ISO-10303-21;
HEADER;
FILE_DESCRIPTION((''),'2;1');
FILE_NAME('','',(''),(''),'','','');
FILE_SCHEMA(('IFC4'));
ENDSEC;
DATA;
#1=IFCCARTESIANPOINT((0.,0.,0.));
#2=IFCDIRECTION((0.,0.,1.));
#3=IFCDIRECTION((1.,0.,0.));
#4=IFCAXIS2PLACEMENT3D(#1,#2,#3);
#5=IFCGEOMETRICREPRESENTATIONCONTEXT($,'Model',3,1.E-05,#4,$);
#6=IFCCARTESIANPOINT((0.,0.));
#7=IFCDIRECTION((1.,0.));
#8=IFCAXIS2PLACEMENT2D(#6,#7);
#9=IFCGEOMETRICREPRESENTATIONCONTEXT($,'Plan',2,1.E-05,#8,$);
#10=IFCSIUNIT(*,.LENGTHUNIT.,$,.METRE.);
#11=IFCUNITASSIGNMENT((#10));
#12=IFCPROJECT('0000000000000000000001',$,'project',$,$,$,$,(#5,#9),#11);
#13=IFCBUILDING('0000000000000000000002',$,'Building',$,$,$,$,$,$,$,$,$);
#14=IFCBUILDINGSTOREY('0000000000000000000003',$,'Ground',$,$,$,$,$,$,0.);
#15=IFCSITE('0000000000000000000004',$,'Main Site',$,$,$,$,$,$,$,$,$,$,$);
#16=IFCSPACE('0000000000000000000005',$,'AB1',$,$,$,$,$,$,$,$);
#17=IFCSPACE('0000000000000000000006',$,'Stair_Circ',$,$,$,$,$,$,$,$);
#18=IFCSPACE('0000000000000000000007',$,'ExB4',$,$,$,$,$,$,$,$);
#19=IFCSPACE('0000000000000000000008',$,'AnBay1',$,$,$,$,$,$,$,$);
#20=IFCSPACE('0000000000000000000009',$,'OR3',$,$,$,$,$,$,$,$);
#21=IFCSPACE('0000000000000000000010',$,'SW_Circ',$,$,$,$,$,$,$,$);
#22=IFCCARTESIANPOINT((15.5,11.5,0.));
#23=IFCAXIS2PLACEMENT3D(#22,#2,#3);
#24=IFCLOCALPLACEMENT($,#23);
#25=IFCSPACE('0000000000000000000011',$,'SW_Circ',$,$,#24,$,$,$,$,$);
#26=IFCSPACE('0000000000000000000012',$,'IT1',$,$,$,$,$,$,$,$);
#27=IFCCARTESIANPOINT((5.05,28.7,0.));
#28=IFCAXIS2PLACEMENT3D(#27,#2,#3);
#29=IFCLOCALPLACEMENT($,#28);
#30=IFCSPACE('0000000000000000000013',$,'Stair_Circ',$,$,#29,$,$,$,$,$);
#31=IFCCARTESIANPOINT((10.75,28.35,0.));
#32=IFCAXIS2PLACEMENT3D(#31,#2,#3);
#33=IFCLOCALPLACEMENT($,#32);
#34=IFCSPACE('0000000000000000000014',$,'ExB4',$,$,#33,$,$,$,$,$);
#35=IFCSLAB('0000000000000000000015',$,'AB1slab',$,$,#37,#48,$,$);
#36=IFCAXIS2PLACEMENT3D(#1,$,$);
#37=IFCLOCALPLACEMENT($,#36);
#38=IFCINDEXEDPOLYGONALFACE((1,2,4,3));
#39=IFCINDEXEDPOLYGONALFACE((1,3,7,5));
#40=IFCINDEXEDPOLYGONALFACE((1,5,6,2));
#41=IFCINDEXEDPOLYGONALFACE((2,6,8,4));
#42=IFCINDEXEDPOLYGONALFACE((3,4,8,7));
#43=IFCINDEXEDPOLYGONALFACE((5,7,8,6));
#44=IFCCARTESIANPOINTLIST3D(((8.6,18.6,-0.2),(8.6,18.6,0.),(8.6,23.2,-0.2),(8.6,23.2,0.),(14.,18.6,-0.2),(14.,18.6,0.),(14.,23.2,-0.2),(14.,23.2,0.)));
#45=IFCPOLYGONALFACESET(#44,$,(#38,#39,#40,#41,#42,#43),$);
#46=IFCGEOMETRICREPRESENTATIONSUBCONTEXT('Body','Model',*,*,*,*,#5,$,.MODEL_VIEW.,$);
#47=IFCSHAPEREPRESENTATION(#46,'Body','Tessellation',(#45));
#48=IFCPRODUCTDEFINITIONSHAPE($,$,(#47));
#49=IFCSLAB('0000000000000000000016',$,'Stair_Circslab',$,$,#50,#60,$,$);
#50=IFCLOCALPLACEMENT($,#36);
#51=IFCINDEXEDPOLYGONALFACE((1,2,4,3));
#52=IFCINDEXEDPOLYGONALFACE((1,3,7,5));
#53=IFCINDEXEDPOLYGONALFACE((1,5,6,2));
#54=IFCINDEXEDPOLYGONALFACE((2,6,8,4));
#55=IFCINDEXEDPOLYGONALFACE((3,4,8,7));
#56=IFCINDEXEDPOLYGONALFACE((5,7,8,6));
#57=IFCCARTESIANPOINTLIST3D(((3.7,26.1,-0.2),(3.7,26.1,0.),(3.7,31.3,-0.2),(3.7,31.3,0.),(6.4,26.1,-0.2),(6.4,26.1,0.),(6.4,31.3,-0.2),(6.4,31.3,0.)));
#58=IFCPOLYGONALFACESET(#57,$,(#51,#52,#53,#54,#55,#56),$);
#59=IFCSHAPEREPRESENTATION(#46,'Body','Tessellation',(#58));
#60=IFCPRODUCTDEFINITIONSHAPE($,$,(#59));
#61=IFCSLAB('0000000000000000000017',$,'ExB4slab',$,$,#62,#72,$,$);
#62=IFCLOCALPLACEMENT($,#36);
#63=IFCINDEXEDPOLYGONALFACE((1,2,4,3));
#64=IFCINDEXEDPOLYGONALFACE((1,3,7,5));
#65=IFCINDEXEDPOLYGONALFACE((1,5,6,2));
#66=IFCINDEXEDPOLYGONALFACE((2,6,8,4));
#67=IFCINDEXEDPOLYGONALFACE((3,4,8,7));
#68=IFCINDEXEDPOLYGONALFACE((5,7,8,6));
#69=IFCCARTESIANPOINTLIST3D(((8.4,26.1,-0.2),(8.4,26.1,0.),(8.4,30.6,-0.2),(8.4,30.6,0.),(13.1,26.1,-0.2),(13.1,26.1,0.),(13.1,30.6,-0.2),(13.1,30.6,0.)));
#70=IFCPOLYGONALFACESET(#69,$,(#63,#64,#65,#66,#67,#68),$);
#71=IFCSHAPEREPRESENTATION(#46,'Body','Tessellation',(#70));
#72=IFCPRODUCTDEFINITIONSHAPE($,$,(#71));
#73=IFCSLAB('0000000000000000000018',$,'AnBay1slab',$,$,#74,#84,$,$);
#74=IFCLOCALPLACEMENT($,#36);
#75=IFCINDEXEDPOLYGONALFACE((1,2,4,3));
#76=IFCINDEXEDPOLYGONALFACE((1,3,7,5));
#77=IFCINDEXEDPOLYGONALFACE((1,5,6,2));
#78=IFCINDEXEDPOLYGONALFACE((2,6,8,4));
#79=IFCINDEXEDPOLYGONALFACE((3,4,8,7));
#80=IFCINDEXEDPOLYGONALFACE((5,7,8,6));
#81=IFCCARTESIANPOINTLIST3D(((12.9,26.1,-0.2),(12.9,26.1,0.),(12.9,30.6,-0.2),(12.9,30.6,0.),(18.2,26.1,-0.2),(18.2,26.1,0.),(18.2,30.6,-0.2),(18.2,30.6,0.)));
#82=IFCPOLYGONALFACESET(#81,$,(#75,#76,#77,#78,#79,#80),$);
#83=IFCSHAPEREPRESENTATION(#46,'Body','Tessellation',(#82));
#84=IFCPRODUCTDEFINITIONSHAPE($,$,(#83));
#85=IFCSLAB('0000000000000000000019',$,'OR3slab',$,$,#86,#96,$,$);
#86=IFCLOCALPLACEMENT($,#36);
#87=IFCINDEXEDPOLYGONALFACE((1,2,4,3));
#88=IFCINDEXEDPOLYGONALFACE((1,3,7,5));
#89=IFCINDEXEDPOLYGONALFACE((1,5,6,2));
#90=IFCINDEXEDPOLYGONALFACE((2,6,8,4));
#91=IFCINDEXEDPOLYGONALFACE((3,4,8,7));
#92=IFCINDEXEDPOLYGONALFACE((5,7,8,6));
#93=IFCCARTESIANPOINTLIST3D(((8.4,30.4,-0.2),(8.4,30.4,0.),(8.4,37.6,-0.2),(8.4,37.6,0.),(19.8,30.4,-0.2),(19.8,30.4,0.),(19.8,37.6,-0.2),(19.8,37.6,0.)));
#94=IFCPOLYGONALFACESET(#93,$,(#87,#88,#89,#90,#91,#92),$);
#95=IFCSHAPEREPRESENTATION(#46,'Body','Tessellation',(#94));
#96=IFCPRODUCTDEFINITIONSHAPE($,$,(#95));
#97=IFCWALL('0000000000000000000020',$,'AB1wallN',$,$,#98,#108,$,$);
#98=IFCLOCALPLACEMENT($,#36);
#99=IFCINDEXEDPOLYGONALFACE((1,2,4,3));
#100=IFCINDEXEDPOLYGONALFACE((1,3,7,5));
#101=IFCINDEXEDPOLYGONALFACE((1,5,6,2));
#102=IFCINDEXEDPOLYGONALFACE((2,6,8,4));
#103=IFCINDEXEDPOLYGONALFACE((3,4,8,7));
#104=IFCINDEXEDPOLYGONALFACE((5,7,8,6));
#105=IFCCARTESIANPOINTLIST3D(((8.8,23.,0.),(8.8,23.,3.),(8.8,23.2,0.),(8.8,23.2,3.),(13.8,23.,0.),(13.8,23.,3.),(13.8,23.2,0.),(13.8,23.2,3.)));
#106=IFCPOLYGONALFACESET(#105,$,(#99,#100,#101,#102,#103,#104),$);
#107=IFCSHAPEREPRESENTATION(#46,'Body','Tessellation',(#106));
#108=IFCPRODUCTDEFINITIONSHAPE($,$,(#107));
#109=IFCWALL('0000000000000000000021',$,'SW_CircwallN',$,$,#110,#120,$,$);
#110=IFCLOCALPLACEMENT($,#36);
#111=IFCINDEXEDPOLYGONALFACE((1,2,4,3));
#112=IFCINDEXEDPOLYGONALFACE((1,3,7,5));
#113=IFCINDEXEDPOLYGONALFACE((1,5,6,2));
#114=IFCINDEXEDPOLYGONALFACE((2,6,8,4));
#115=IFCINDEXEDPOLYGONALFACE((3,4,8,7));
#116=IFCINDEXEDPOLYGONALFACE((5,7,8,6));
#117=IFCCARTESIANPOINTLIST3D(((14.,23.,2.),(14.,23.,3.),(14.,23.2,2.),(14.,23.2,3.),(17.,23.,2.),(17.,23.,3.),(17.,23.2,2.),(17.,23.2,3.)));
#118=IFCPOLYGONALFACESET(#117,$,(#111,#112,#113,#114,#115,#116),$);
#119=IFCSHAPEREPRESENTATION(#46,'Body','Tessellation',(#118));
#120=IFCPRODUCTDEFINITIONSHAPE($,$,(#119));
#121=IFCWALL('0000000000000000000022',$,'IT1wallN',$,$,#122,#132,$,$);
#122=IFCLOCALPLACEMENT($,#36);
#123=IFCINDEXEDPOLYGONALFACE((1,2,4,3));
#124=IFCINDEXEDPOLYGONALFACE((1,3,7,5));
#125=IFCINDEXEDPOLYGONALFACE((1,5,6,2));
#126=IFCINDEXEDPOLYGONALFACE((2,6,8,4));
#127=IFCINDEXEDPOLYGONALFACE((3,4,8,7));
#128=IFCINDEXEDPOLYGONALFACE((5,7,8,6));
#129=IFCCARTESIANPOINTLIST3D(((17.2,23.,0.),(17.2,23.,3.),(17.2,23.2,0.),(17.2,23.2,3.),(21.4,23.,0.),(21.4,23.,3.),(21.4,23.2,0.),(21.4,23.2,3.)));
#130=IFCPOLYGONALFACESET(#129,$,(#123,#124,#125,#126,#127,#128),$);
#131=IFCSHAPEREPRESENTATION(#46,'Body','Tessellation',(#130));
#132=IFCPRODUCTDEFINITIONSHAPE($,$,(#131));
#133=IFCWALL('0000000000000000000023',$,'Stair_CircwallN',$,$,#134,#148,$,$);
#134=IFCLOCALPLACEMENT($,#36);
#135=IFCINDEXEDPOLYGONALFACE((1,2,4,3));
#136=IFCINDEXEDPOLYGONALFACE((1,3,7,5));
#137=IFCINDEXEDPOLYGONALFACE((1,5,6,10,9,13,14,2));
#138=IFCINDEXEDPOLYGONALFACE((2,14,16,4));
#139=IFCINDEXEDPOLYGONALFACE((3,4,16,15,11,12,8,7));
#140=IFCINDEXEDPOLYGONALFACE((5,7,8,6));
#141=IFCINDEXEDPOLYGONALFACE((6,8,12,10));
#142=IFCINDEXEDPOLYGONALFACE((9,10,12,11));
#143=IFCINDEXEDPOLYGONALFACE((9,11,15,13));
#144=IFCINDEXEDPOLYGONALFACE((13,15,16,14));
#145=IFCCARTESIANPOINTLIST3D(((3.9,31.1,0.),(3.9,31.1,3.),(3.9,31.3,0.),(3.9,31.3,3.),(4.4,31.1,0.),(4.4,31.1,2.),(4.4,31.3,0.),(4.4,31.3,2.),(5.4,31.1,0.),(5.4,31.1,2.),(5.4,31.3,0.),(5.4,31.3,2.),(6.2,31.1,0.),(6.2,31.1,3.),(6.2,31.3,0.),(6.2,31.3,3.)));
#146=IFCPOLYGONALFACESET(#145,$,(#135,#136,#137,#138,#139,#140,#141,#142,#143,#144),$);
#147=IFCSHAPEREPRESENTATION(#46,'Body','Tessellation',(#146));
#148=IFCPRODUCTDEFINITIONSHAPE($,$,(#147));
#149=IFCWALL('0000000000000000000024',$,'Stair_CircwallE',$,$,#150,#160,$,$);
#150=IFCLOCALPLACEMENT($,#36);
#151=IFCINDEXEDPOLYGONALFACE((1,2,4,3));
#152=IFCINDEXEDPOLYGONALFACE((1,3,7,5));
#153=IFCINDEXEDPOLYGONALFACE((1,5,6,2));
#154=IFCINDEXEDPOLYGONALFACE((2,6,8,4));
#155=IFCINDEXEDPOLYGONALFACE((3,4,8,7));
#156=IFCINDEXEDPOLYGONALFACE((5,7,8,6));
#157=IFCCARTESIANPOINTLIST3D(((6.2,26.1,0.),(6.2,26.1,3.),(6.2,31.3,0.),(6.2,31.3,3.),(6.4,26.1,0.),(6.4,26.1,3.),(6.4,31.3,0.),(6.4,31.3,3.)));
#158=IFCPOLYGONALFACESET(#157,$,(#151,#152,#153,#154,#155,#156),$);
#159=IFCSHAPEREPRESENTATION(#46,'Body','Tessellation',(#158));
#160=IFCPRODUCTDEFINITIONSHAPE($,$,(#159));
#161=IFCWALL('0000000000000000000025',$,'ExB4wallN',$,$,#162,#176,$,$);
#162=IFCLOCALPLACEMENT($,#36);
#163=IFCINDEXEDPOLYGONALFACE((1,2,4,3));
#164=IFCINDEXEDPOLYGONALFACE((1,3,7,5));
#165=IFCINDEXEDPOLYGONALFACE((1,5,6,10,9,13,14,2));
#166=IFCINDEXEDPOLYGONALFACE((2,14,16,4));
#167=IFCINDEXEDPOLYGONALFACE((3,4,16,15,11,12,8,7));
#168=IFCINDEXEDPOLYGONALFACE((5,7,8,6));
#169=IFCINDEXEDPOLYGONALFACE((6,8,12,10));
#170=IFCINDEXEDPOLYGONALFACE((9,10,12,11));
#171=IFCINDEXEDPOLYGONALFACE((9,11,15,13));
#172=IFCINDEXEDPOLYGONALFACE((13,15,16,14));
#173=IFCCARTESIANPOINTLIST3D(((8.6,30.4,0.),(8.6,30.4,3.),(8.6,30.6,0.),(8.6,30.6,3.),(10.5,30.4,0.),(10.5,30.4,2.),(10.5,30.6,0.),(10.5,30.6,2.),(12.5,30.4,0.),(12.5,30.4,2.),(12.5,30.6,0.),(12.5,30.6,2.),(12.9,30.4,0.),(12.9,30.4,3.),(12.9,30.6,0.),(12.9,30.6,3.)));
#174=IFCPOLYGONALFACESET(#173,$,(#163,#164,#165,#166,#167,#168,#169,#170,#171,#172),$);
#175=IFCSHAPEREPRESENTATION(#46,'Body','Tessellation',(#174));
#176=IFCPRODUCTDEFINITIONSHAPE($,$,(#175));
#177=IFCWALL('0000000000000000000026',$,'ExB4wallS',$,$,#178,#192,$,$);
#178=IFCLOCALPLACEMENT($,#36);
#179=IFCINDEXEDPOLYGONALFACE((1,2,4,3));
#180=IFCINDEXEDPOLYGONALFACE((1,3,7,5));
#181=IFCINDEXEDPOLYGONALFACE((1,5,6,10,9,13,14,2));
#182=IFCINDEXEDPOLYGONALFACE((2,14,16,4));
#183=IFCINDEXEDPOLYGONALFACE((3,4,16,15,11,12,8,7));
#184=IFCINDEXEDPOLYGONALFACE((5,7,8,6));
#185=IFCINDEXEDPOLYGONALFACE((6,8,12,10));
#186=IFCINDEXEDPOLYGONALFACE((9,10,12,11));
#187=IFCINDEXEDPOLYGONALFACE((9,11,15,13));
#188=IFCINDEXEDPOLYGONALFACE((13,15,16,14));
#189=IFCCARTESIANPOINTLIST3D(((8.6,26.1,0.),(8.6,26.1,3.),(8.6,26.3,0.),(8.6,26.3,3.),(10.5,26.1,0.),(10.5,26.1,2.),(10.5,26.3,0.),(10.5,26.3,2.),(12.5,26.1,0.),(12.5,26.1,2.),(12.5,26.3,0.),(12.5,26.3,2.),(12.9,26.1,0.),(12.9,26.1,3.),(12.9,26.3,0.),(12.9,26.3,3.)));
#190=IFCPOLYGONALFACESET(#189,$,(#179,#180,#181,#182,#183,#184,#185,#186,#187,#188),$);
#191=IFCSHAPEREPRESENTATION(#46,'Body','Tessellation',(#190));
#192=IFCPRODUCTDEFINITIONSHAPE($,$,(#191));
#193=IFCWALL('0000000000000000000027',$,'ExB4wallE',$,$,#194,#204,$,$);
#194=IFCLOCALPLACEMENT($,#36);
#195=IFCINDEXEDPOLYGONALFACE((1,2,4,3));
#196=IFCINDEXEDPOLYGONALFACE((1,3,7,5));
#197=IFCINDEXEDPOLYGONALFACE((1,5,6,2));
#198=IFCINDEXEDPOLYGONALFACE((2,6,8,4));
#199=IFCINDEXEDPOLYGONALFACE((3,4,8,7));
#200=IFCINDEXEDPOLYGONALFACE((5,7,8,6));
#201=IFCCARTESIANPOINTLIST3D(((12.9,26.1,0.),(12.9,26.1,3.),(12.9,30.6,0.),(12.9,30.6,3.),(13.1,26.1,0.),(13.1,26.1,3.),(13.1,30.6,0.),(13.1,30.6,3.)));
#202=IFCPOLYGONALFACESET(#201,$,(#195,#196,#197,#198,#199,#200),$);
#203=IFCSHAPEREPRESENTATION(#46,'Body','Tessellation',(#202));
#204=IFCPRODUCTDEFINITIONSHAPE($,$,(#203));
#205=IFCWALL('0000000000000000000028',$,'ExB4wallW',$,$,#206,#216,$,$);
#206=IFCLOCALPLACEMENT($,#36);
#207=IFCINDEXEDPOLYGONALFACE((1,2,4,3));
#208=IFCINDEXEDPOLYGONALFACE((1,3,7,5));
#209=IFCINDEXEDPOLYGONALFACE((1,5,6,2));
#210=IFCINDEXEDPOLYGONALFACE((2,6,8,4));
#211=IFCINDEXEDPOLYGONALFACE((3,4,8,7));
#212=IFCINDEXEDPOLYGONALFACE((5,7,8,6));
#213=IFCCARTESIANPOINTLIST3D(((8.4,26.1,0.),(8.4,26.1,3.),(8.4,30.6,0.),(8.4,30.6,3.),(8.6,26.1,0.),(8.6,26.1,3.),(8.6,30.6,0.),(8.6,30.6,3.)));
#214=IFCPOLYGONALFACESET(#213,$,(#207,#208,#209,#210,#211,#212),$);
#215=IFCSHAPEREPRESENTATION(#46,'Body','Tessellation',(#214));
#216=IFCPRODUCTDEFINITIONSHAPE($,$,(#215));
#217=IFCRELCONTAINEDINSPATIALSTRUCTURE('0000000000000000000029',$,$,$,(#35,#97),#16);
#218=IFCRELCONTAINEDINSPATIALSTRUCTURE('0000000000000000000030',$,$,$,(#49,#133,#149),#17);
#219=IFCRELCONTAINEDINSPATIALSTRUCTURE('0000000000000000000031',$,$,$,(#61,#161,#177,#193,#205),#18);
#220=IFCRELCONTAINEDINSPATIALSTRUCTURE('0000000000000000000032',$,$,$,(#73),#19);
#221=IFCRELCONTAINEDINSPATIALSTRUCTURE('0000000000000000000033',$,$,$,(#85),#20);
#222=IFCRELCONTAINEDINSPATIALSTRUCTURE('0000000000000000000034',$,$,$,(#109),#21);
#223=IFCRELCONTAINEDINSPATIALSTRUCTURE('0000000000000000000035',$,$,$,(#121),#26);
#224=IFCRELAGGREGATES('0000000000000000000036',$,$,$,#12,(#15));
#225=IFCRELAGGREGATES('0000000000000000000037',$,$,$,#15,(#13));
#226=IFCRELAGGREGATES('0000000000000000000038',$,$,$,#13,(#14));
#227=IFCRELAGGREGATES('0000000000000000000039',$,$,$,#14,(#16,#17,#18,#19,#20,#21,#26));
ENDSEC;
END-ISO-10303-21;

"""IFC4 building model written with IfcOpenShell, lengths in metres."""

from ifc_helpers import new_model, si_unit, frame, origin_with_axes, origin_2d_with_axis, place, context, subcontext, project, spatial, indexed_curve, rectangle, outline, extrude, element, save


model = new_model("IFC4")

# Units and contexts
model_context = context("Model", 3, precision=1e-05, world=origin_with_axes())
plan_context = context("Plan", 2, precision=1e-05, world=origin_2d_with_axis())
body_context = subcontext(model_context, "Body", "Model", "MODEL_VIEW")
ifc_project = project(units=[si_unit("LENGTHUNIT", "METRE")], contexts=[model_context, plan_context])

# Site, building, storey, space
site = spatial("IfcSite", under=ifc_project, Name="Main Site")
building = spatial("IfcBuilding", under=site, Name="Building")
storey = spatial("IfcBuildingStorey", under=building, Name="Ground", Elevation=0.0)
space_1 = spatial("IfcSpace", under=storey, Name="AB1")

# Slab
slab_1_placement = place(None, frame((11.3, 20.9, -0.2), z_axis=(0.0, 0.0, 1.0), x_axis=(1.0, 0.0, 0.0)))
element("IfcSlab", 1, at=slab_1_placement, inside=space_1, Name="AB1slab", context=body_context, shape_type="SweptSolid", body=[
    extrude(rectangle(XDim=5.4, YDim=4.6), origin_with_axes(), (0.0, 0.0, 1.0), 0.2),
])

# Shared definitions
space_2 = spatial("IfcSpace", under=storey, Name="Stair_Circ")

# Slab
slab_2_placement = place(None, frame((5.05, 28.7, -0.2), z_axis=(0.0, 0.0, 1.0), x_axis=(1.0, 0.0, 0.0)))
element("IfcSlab", 2, at=slab_2_placement, inside=space_2, Name="Stair_Circslab", context=body_context, shape_type="SweptSolid", body=[
    extrude(rectangle(XDim=2.7, YDim=5.2), origin_with_axes(), (0.0, 0.0, 1.0), 0.2),
])

# Shared definitions
space_3 = spatial("IfcSpace", under=storey, Name="ExB4")

# Slab
slab_3_placement = place(None, frame((10.75, 28.35, -0.2), z_axis=(0.0, 0.0, 1.0), x_axis=(1.0, 0.0, 0.0)))
element("IfcSlab", 3, at=slab_3_placement, inside=space_3, Name="ExB4slab", context=body_context, shape_type="SweptSolid", body=[
    extrude(rectangle(XDim=4.7, YDim=4.5), origin_with_axes(), (0.0, 0.0, 1.0), 0.2),
])

# Shared definitions
space_4 = spatial("IfcSpace", under=storey, Name="AnBay1")

# Slab
slab_4_placement = place(None, frame((15.55, 28.35, -0.2), z_axis=(0.0, 0.0, 1.0), x_axis=(1.0, 0.0, 0.0)))
element("IfcSlab", 4, at=slab_4_placement, inside=space_4, Name="AnBay1slab", context=body_context, shape_type="SweptSolid", body=[
    extrude(rectangle(XDim=5.3, YDim=4.5), origin_with_axes(), (0.0, 0.0, 1.0), 0.2),
])

# Shared definitions
space_5 = spatial("IfcSpace", under=storey, Name="OR3")

# Slab
slab_5_placement = place(None, frame((14.1, 34.0, -0.2), z_axis=(0.0, 0.0, 1.0), x_axis=(1.0, 0.0, 0.0)))
element("IfcSlab", 5, at=slab_5_placement, inside=space_5, Name="OR3slab", context=body_context, shape_type="SweptSolid", body=[
    extrude(rectangle(XDim=11.4, YDim=7.2), origin_with_axes(), (0.0, 0.0, 1.0), 0.2),
])

# Wall
wall_1_placement = place(None, frame((8.8, 23.0, 0.0), z_axis=(0.0, 0.0, 1.0), x_axis=(1.0, 0.0, 0.0)))
element("IfcWall", 6, at=wall_1_placement, inside=space_1, Name="AB1wallN", context=body_context, shape_type="SweptSolid", body=[
    extrude(outline(indexed_curve([(0.0, 0.0), (0.0, 0.2), (5.0, 0.2), (5.0, 0.0), (0.0, 0.0)], self_intersect=False)), origin_with_axes(), (0.0, 0.0, 1.0), 3.0),
])

# Shared definitions
space_6 = spatial("IfcSpace", under=storey, Name="SW_Circ")

# Wall
wall_2_placement = place(None, frame((14.0, 23.0, 0.0), z_axis=(0.0, 0.0, 1.0), x_axis=(1.0, 0.0, 0.0)))
wall_2 = element("IfcWall", 7, at=wall_2_placement, inside=space_6, Name="SW_CircwallN", context=body_context, shape_type="SweptSolid", body=[
    extrude(outline(indexed_curve([(0.0, 0.0), (0.0, 0.2), (3.0, 0.2), (3.0, 0.0), (0.0, 0.0)], self_intersect=False)), origin_with_axes(), (0.0, 0.0, 1.0), 3.0),
])

# Shared definitions
space_7_placement = place(None, frame((15.5, 11.5, 0.0), z_axis=(0.0, 0.0, 1.0), x_axis=(1.0, 0.0, 0.0)))
space_7 = spatial("IfcSpace", at=space_7_placement, Name="SW_Circ")

# Opening
opening_1_placement = place(wall_2_placement, origin_with_axes())
element("IfcOpeningElement", 8, at=opening_1_placement, inside=space_7, cuts=wall_2, context=body_context, shape_type="SweptSolid", body=[
    extrude(outline(indexed_curve([(0.0, 0.0), (0.0, 0.4), (3.0, 0.4), (3.0, 0.0), (0.0, 0.0)], self_intersect=False)), origin_with_axes(), (0.0, 0.0, 1.0), 2.0),
])

# Shared definitions
space_8 = spatial("IfcSpace", under=storey, Name="IT1")

# Walls
wall_3_placement = place(None, frame((17.2, 23.0, 0.0), z_axis=(0.0, 0.0, 1.0), x_axis=(1.0, 0.0, 0.0)))
element("IfcWall", 9, at=wall_3_placement, inside=space_8, Name="IT1wallN", context=body_context, shape_type="SweptSolid", body=[
    extrude(outline(indexed_curve([(0.0, 0.0), (0.0, 0.2), (4.2, 0.2), (4.2, 0.0), (0.0, 0.0)], self_intersect=False)), origin_with_axes(), (0.0, 0.0, 1.0), 3.0),
])
wall_4_placement = place(None, frame((3.9, 31.1, 0.0), z_axis=(0.0, 0.0, 1.0), x_axis=(1.0, 0.0, 0.0)))
wall_4 = element("IfcWall", 10, at=wall_4_placement, inside=space_2, Name="Stair_CircwallN", context=body_context, shape_type="SweptSolid", body=[
    extrude(outline(indexed_curve([(0.0, 0.0), (0.0, 0.2), (2.3, 0.2), (2.3, 0.0), (0.0, 0.0)], self_intersect=False)), origin_with_axes(), (0.0, 0.0, 1.0), 3.0),
])

# Shared definitions
space_9_placement = place(None, frame((5.05, 28.7, 0.0), z_axis=(0.0, 0.0, 1.0), x_axis=(1.0, 0.0, 0.0)))
space_9 = spatial("IfcSpace", at=space_9_placement, Name="Stair_Circ")

# Opening
opening_2_placement = place(wall_4_placement, frame((0.5, 0.0, 0.0), z_axis=(0.0, 0.0, 1.0), x_axis=(1.0, 0.0, 0.0)))
element("IfcOpeningElement", 11, at=opening_2_placement, inside=space_9, cuts=wall_4, context=body_context, shape_type="SweptSolid", body=[
    extrude(outline(indexed_curve([(0.0, 0.0), (0.0, 0.4), (1.0, 0.4), (1.0, 0.0), (0.0, 0.0)], self_intersect=False)), origin_with_axes(), (0.0, 0.0, 1.0), 2.0),
])

# Walls
wall_5_placement = place(None, frame((6.4, 26.1, 0.0), z_axis=(0.0, 0.0, 1.0), x_axis=(0.0, 1.0, 0.0)))
element("IfcWall", 12, at=wall_5_placement, inside=space_2, Name="Stair_CircwallE", context=body_context, shape_type="SweptSolid", body=[
    extrude(outline(indexed_curve([(0.0, 0.0), (0.0, 0.2), (5.2, 0.2), (5.2, 0.0), (0.0, 0.0)], self_intersect=False)), origin_with_axes(), (0.0, 0.0, 1.0), 3.0),
])
wall_6_placement = place(None, frame((8.6, 30.4, 0.0), z_axis=(0.0, 0.0, 1.0), x_axis=(1.0, 0.0, 0.0)))
wall_6 = element("IfcWall", 13, at=wall_6_placement, inside=space_3, Name="ExB4wallN", context=body_context, shape_type="SweptSolid", body=[
    extrude(outline(indexed_curve([(0.0, 0.0), (0.0, 0.2), (4.3, 0.2), (4.3, 0.0), (0.0, 0.0)], self_intersect=False)), origin_with_axes(), (0.0, 0.0, 1.0), 3.0),
])

# Shared definitions
space_10_placement = place(None, frame((10.75, 28.35, 0.0), z_axis=(0.0, 0.0, 1.0), x_axis=(1.0, 0.0, 0.0)))
space_10 = spatial("IfcSpace", at=space_10_placement, Name="ExB4")

# Opening
opening_3_placement = place(wall_6_placement, frame((1.9, 0.0, 0.0), z_axis=(0.0, 0.0, 1.0), x_axis=(1.0, 0.0, 0.0)))
element("IfcOpeningElement", 14, at=opening_3_placement, inside=space_10, cuts=wall_6, context=body_context, shape_type="SweptSolid", body=[
    extrude(outline(indexed_curve([(0.0, 0.0), (0.0, 0.4), (2.0, 0.4), (2.0, 0.0), (0.0, 0.0)], self_intersect=False)), origin_with_axes(), (0.0, 0.0, 1.0), 2.0),
])

# Wall, opening
wall_7_placement = place(None, frame((8.6, 26.1, 0.0), z_axis=(0.0, 0.0, 1.0), x_axis=(1.0, 0.0, 0.0)))
wall_7 = element("IfcWall", 15, at=wall_7_placement, inside=space_3, Name="ExB4wallS", context=body_context, shape_type="SweptSolid", body=[
    extrude(outline(indexed_curve([(0.0, 0.0), (0.0, 0.2), (4.3, 0.2), (4.3, 0.0), (0.0, 0.0)], self_intersect=False)), origin_with_axes(), (0.0, 0.0, 1.0), 3.0),
])
opening_4_placement = place(wall_7_placement, frame((1.9, 0.0, 0.0), z_axis=(0.0, 0.0, 1.0), x_axis=(1.0, 0.0, 0.0)))
element("IfcOpeningElement", 16, at=opening_4_placement, inside=space_10, cuts=wall_7, context=body_context, shape_type="SweptSolid", body=[
    extrude(outline(indexed_curve([(0.0, 0.0), (0.0, 0.4), (2.0, 0.4), (2.0, 0.0), (0.0, 0.0)], self_intersect=False)), origin_with_axes(), (0.0, 0.0, 1.0), 2.0),
])

# Walls
for number, where, z_axis, x_axis, name in (
    (17, (13.1, 26.1, 0.0), (0.0, 0.0, 1.0), (0.0, 1.0, 0.0), "ExB4wallE"),
    (18, (8.6, 26.1, 0.0), (0.0, 0.0, 1.0), (0.0, 1.0, 0.0), "ExB4wallW"),
):
    element("IfcWall", number, at=place(None, frame(where, z_axis=z_axis, x_axis=x_axis)), inside=space_3, Name=name, context=body_context, shape_type="SweptSolid", body=[
        extrude(outline(indexed_curve([(0.0, 0.0), (0.0, 0.2), (4.5, 0.2), (4.5, 0.0), (0.0, 0.0)], self_intersect=False)), origin_with_axes(), (0.0, 0.0, 1.0), 3.0),
    ])

save(model, "model.ifc")
